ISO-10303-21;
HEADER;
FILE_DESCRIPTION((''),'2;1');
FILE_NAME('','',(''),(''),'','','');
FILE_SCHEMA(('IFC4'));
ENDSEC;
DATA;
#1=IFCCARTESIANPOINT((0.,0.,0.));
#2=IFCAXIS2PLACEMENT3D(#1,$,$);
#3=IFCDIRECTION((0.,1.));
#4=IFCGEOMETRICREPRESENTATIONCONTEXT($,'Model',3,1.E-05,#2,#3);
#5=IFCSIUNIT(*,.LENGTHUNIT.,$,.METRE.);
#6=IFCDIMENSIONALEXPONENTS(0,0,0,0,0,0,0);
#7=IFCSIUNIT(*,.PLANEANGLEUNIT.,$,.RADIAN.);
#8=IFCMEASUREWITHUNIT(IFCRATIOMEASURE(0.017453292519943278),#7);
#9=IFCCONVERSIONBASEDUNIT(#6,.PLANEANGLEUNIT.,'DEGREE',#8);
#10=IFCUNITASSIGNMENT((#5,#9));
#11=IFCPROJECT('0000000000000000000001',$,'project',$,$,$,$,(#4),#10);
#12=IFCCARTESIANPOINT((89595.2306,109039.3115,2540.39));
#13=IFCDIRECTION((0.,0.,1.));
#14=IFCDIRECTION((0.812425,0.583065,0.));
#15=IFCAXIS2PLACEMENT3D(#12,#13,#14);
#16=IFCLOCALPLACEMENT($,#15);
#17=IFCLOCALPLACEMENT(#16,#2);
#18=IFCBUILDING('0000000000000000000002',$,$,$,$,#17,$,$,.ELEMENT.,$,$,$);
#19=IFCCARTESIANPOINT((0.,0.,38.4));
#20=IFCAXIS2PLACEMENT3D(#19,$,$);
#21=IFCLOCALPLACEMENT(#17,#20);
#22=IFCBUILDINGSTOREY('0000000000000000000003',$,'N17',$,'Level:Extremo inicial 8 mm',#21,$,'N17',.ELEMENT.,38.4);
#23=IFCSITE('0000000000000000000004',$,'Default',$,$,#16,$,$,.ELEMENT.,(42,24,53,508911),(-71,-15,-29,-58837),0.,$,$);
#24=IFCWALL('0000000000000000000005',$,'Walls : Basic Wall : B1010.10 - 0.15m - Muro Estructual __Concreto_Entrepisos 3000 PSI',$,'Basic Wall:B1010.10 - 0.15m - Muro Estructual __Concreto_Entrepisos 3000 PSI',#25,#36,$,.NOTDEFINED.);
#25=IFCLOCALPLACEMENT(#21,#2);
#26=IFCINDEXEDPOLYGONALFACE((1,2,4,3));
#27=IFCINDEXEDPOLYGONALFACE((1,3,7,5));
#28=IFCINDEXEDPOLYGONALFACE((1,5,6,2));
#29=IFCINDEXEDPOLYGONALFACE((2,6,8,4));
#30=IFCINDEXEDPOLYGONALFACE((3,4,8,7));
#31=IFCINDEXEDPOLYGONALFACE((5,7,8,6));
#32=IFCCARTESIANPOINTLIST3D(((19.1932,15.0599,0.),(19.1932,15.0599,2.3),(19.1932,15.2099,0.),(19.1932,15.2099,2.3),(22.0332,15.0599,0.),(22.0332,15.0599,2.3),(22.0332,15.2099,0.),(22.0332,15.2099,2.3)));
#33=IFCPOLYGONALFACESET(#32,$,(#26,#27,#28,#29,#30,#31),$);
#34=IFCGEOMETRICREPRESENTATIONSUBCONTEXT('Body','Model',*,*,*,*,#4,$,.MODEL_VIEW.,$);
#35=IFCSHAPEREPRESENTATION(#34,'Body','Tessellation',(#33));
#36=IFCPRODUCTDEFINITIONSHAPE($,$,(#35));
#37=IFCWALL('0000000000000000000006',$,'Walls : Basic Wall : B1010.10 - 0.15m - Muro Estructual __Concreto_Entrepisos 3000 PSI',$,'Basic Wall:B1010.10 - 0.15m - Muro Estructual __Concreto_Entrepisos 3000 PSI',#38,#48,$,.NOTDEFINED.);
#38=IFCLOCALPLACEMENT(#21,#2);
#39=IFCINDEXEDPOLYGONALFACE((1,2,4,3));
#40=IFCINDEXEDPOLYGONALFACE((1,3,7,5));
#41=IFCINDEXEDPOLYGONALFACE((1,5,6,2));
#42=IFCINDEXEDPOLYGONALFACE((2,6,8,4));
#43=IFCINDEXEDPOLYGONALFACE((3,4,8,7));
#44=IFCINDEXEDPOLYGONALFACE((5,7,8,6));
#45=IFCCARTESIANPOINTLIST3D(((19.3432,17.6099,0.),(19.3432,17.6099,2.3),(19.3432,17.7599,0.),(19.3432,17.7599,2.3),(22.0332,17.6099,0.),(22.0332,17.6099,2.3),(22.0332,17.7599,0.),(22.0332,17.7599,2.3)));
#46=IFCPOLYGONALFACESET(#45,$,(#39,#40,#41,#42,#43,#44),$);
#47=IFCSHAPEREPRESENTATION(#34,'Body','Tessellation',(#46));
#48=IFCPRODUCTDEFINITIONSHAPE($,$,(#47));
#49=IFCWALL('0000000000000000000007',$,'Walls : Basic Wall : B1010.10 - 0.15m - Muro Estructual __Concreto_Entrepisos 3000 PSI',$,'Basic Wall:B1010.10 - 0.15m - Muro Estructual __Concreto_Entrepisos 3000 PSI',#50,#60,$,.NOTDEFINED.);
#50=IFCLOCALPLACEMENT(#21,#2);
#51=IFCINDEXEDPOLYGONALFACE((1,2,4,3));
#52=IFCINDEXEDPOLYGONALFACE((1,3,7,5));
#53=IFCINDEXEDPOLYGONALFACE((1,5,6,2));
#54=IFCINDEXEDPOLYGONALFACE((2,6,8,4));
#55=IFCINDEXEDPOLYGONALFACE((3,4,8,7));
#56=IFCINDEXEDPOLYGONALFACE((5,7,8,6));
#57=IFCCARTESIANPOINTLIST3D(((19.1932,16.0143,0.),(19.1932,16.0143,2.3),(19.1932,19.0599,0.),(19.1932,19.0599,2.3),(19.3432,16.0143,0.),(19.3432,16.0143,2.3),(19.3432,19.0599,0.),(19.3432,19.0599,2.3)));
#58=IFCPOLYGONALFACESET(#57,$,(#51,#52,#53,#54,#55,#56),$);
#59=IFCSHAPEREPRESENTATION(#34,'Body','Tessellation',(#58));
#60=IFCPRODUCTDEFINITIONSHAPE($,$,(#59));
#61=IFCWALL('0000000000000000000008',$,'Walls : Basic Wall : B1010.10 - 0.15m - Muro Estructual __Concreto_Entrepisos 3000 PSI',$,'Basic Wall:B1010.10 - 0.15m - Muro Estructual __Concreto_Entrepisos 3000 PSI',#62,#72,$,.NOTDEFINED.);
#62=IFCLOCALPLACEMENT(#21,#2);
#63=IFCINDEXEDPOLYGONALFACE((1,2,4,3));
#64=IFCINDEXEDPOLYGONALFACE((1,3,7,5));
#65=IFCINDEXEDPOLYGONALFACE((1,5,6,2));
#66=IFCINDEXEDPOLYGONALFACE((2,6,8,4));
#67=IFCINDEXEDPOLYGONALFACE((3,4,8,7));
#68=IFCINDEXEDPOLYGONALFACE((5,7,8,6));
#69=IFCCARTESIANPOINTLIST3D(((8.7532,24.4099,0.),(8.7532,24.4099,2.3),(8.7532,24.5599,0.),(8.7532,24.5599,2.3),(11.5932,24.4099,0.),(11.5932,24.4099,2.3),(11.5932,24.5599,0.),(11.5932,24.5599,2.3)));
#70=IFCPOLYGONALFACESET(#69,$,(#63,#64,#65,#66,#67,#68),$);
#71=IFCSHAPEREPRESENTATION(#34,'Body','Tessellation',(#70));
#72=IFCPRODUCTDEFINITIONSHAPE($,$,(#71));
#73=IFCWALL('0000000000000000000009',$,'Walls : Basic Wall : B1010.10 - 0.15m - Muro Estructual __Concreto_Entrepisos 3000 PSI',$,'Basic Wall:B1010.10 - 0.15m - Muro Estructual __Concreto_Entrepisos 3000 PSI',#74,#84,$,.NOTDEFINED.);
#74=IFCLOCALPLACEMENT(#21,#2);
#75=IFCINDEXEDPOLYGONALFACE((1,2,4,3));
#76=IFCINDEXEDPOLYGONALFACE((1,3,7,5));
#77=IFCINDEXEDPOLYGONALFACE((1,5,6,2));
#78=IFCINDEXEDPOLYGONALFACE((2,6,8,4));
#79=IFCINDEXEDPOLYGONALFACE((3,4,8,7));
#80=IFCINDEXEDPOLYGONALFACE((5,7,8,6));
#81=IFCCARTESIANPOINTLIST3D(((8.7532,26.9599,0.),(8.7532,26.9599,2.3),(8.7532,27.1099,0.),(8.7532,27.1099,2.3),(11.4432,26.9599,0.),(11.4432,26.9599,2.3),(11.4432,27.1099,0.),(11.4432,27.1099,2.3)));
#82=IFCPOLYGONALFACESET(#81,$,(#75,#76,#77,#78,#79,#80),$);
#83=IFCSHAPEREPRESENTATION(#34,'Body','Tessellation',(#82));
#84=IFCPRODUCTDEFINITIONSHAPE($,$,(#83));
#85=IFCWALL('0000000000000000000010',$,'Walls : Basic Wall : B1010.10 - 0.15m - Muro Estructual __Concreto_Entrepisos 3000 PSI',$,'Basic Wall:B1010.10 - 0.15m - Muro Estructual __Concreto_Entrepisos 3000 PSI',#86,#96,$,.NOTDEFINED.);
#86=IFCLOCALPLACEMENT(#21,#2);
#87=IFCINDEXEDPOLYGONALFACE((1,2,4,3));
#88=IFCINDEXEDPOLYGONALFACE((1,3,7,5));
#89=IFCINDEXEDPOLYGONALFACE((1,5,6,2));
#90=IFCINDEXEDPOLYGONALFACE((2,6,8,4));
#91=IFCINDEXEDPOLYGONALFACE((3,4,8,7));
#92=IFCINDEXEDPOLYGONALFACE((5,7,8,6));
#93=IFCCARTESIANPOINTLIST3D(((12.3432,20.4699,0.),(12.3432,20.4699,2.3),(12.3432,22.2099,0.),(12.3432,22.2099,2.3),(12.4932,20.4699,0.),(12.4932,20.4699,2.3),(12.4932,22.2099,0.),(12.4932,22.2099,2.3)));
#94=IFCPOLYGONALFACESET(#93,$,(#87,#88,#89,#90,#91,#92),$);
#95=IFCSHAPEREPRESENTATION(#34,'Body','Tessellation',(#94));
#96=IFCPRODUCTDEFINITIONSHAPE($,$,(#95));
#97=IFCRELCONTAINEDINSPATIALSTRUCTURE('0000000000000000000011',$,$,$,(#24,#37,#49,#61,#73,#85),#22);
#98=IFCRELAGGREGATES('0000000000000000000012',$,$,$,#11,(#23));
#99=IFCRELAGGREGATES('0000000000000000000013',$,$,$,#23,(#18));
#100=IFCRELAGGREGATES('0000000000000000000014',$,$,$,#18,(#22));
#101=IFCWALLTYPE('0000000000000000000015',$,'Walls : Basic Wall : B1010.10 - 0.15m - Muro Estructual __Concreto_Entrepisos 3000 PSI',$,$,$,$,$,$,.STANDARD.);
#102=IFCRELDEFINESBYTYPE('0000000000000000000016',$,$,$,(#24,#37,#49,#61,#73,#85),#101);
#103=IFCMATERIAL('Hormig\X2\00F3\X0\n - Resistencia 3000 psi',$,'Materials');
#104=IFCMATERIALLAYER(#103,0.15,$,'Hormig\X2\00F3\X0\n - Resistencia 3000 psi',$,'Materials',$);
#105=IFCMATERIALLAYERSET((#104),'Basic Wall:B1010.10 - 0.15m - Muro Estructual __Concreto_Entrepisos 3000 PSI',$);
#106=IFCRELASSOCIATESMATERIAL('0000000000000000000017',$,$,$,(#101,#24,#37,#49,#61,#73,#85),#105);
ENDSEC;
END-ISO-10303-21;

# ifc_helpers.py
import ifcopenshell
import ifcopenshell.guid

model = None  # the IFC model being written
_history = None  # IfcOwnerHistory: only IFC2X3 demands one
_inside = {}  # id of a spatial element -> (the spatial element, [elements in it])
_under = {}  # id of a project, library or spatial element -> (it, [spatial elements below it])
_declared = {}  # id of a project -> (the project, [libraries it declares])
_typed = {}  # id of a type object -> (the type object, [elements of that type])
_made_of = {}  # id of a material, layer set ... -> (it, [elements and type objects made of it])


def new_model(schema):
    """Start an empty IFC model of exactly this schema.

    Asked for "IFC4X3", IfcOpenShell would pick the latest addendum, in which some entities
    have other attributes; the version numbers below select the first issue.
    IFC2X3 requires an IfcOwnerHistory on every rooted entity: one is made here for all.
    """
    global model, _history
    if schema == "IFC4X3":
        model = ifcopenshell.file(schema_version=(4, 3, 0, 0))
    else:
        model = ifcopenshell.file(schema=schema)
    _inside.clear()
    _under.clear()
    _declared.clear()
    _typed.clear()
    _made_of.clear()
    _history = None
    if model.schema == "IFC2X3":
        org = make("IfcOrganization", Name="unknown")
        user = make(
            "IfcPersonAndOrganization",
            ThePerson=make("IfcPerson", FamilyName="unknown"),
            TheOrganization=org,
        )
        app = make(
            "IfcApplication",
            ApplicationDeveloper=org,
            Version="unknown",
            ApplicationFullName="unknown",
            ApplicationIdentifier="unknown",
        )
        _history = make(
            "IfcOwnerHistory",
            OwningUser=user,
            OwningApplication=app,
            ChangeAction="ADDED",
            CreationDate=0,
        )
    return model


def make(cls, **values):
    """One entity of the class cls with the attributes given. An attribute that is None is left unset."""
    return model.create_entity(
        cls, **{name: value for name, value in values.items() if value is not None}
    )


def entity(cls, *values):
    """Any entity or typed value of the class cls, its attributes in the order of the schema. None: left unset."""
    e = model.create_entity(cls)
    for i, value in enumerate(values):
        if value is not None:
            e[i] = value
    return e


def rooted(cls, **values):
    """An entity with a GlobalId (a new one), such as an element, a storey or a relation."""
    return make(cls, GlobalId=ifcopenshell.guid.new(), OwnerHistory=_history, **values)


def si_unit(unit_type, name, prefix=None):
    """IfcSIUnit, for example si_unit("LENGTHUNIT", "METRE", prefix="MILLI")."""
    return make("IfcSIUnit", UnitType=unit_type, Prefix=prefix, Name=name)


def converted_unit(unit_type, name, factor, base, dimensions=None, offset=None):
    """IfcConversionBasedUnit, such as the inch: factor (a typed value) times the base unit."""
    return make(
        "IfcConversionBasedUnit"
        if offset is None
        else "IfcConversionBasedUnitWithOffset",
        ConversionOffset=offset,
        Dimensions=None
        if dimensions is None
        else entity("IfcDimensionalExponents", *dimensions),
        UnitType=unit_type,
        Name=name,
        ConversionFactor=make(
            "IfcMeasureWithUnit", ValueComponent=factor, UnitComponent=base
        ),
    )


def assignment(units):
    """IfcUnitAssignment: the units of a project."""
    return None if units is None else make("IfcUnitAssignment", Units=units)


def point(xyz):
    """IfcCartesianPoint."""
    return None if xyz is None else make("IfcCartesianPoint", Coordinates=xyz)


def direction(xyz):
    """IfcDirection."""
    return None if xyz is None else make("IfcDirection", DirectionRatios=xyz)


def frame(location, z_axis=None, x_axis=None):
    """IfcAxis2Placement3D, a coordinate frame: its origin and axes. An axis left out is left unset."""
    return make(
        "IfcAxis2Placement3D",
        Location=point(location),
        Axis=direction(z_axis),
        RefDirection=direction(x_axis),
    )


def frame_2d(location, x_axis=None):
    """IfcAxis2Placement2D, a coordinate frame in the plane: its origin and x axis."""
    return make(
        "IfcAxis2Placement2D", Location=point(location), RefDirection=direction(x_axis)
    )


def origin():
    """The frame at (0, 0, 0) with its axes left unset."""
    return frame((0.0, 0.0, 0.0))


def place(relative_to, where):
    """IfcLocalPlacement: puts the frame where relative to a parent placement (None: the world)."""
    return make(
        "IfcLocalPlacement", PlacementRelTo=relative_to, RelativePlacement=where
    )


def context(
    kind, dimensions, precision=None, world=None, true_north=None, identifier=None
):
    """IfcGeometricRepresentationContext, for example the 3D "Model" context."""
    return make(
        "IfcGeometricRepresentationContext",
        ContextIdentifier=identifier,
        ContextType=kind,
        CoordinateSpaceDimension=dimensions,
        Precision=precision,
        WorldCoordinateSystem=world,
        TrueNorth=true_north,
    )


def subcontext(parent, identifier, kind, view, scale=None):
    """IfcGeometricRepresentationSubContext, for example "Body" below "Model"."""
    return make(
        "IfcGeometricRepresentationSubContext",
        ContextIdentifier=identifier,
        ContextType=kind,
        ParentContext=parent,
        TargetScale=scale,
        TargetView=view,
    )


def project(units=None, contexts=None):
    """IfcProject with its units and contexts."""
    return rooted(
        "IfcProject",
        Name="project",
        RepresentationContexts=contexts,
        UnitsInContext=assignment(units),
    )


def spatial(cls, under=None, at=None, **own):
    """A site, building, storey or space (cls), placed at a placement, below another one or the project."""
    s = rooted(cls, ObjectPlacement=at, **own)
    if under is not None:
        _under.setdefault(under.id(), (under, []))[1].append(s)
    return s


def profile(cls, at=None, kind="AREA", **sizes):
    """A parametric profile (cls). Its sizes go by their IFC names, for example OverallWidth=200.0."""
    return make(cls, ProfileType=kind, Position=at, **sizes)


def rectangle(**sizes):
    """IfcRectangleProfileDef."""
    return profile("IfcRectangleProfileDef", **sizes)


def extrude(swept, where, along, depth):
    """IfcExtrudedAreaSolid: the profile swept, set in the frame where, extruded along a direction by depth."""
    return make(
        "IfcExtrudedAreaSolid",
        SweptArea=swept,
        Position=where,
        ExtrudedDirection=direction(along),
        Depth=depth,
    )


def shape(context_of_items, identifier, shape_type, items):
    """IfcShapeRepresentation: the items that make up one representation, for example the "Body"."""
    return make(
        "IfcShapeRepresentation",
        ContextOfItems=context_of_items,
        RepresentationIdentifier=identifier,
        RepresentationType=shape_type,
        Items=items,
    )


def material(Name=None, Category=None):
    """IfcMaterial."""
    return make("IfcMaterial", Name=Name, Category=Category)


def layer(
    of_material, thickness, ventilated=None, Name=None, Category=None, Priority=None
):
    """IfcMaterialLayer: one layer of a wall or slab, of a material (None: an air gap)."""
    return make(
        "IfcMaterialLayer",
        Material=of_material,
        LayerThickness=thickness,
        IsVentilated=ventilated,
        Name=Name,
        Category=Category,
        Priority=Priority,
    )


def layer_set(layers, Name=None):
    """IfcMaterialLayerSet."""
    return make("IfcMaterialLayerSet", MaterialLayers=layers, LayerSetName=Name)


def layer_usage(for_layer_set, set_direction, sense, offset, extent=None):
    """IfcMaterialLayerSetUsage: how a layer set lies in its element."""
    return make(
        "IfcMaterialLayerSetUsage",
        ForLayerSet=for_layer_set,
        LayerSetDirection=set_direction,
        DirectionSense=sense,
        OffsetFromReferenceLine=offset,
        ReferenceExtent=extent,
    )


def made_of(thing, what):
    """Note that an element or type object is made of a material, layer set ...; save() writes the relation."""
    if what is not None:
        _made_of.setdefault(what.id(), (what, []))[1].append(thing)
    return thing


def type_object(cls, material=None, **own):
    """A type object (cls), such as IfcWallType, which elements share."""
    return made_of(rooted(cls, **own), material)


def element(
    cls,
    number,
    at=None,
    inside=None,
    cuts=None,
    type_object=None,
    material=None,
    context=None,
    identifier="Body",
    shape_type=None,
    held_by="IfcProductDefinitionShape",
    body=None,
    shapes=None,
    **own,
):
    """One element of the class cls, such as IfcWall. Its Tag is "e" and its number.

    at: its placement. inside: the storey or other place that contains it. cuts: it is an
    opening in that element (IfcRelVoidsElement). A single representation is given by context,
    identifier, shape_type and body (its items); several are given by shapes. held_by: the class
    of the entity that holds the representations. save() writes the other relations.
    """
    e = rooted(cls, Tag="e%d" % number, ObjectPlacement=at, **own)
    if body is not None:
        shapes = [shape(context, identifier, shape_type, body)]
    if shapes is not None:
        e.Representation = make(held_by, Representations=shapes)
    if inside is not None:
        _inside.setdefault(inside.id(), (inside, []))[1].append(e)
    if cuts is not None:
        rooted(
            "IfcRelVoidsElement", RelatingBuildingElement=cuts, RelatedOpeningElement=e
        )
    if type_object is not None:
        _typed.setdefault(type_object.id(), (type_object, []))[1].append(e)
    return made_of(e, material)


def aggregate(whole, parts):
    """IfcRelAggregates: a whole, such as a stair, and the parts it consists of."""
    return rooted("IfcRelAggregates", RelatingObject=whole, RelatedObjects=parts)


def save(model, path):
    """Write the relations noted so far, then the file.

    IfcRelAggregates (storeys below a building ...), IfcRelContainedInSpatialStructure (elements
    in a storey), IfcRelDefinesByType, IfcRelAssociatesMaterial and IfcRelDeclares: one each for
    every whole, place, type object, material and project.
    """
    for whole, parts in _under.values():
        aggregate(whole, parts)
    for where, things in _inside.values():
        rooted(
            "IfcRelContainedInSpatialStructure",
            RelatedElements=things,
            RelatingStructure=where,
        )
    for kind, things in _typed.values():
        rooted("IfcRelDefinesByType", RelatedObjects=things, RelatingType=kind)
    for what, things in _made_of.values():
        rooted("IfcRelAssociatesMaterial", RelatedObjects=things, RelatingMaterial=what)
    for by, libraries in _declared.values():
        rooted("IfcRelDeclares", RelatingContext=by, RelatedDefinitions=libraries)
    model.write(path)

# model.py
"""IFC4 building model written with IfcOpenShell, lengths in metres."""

from ifc_helpers import new_model, entity, si_unit, converted_unit, direction, frame, frame_2d, origin, place, context, subcontext, project, spatial, rectangle, extrude, material, layer, layer_set, layer_usage, type_object, element, save


model = new_model("IFC4")

# Units and contexts
model_context = context("Model", 3, precision=1e-05, world=origin(), true_north=direction((0.0, 1.0)))
body_context = subcontext(model_context, "Body", "Model", "MODEL_VIEW")
ifc_project = project(units=[si_unit("LENGTHUNIT", "METRE"), converted_unit("PLANEANGLEUNIT", "DEGREE", entity("IfcRatioMeasure", 0.017453292519943278), si_unit("PLANEANGLEUNIT", "RADIAN"), dimensions=[0, 0, 0, 0, 0, 0, 0])], contexts=[model_context])

# Site, building, storey
site_placement = place(None, frame((89595.2306, 109039.3115, 2540.39), z_axis=(0.0, 0.0, 1.0), x_axis=(0.812425, 0.583065, 0.0)))
site = spatial("IfcSite", under=ifc_project, at=site_placement, Name="Default", CompositionType="ELEMENT", RefLatitude=(42, 24, 53, 508911), RefLongitude=(-71, -15, -29, -58837), RefElevation=0.0)
building_placement = place(site_placement, origin())
building = spatial("IfcBuilding", under=site, at=building_placement, CompositionType="ELEMENT")
storey_placement = place(building_placement, frame((0.0, 0.0, 38.4)))
storey = spatial("IfcBuildingStorey", under=building, at=storey_placement, Name="N17", ObjectType="Level:Extremo inicial 8 mm", LongName="N17", CompositionType="ELEMENT", Elevation=38.4)

# Walls
ifc_material = material(Name="Hormigón - Resistencia 3000 psi", Category="Materials")
ifc_layer_1 = layer(ifc_material, 0.15, Name="Hormigón - Resistencia 3000 psi", Category="Materials")
ifc_layer_set_1 = layer_set([ifc_layer_1], Name="Basic Wall:B1010.10 - 0.15m - Muro Estructual __Concreto_Entrepisos 3000 PSI")
ifc_layer_usage_1 = layer_usage(ifc_layer_set_1, "AXIS2", "NEGATIVE", 0.075)
wall_type_1 = type_object("IfcWallType", Name="Walls : Basic Wall : B1010.10 - 0.15m - Muro Estructual __Concreto_Entrepisos 3000 PSI", PredefinedType="STANDARD", material=ifc_layer_set_1)
wall_1_placement = place(storey_placement, frame((22.0332, 15.1349, 0.0), z_axis=(0.0, 0.0, 1.0), x_axis=(-1.0, 0.0, 0.0)))
element("IfcWall", 1, at=wall_1_placement, inside=storey, type_object=wall_type_1, material=ifc_layer_usage_1, Name="Walls : Basic Wall : B1010.10 - 0.15m - Muro Estructual __Concreto_Entrepisos 3000 PSI", ObjectType="Basic Wall:B1010.10 - 0.15m - Muro Estructual __Concreto_Entrepisos 3000 PSI", PredefinedType="NOTDEFINED", context=body_context, shape_type="SweptSolid", body=[
    extrude(rectangle(XDim=2.84, YDim=0.15, at=frame_2d((1.42, 0.0), x_axis=(-1.0, 0.0))), origin(), (0.0, 0.0, 1.0), 2.3),
])
ifc_layer_usage_2 = layer_usage(ifc_layer_set_1, "AXIS2", "NEGATIVE", 0.075)
wall_2_placement = place(storey_placement, frame((22.0332, 17.6849, 0.0), z_axis=(0.0, 0.0, 1.0), x_axis=(-1.0, 0.0, 0.0)))
element("IfcWall", 2, at=wall_2_placement, inside=storey, type_object=wall_type_1, material=ifc_layer_usage_2, Name="Walls : Basic Wall : B1010.10 - 0.15m - Muro Estructual __Concreto_Entrepisos 3000 PSI", ObjectType="Basic Wall:B1010.10 - 0.15m - Muro Estructual __Concreto_Entrepisos 3000 PSI", PredefinedType="NOTDEFINED", context=body_context, shape_type="SweptSolid", body=[
    extrude(rectangle(XDim=2.69, YDim=0.15, at=frame_2d((1.345, 0.0), x_axis=(-1.0, 0.0))), origin(), (0.0, 0.0, 1.0), 2.3),
])
ifc_layer_usage_3 = layer_usage(ifc_layer_set_1, "AXIS2", "NEGATIVE", 0.075)
wall_3_placement = place(storey_placement, frame((19.2682, 16.0143, 0.0), z_axis=(0.0, 0.0, 1.0), x_axis=(0.0, 1.0, 0.0)))
element("IfcWall", 3, at=wall_3_placement, inside=storey, type_object=wall_type_1, material=ifc_layer_usage_3, Name="Walls : Basic Wall : B1010.10 - 0.15m - Muro Estructual __Concreto_Entrepisos 3000 PSI", ObjectType="Basic Wall:B1010.10 - 0.15m - Muro Estructual __Concreto_Entrepisos 3000 PSI", PredefinedType="NOTDEFINED", context=body_context, shape_type="SweptSolid", body=[
    extrude(rectangle(XDim=3.0455, YDim=0.15, at=frame_2d((1.5228, 0.0), x_axis=(-1.0, 0.0))), origin(), (0.0, 0.0, 1.0), 2.3),
])
ifc_layer_usage_4 = layer_usage(ifc_layer_set_1, "AXIS2", "NEGATIVE", 0.075)
wall_4_placement = place(storey_placement, frame((8.7532, 24.4849, 0.0)))
element("IfcWall", 4, at=wall_4_placement, inside=storey, type_object=wall_type_1, material=ifc_layer_usage_4, Name="Walls : Basic Wall : B1010.10 - 0.15m - Muro Estructual __Concreto_Entrepisos 3000 PSI", ObjectType="Basic Wall:B1010.10 - 0.15m - Muro Estructual __Concreto_Entrepisos 3000 PSI", PredefinedType="NOTDEFINED", context=body_context, shape_type="SweptSolid", body=[
    extrude(rectangle(XDim=2.84, YDim=0.15, at=frame_2d((1.42, 0.0), x_axis=(-1.0, 0.0))), origin(), (0.0, 0.0, 1.0), 2.3),
])
ifc_layer_usage_5 = layer_usage(ifc_layer_set_1, "AXIS2", "NEGATIVE", 0.075)
wall_5_placement = place(storey_placement, frame((8.7532, 27.0349, 0.0)))
element("IfcWall", 5, at=wall_5_placement, inside=storey, type_object=wall_type_1, material=ifc_layer_usage_5, Name="Walls : Basic Wall : B1010.10 - 0.15m - Muro Estructual __Concreto_Entrepisos 3000 PSI", ObjectType="Basic Wall:B1010.10 - 0.15m - Muro Estructual __Concreto_Entrepisos 3000 PSI", PredefinedType="NOTDEFINED", context=body_context, shape_type="SweptSolid", body=[
    extrude(rectangle(XDim=2.69, YDim=0.15, at=frame_2d((1.345, 0.0), x_axis=(-1.0, 0.0))), origin(), (0.0, 0.0, 1.0), 2.3),
])
ifc_layer_usage_6 = layer_usage(ifc_layer_set_1, "AXIS2", "POSITIVE", -0.075)
wall_6_placement = place(storey_placement, frame((12.4182, 20.4699, 0.0), z_axis=(0.0, 0.0, 1.0), x_axis=(0.0, 1.0, 0.0)))
element("IfcWall", 6, at=wall_6_placement, inside=storey, type_object=wall_type_1, material=ifc_layer_usage_6, Name="Walls : Basic Wall : B1010.10 - 0.15m - Muro Estructual __Concreto_Entrepisos 3000 PSI", ObjectType="Basic Wall:B1010.10 - 0.15m - Muro Estructual __Concreto_Entrepisos 3000 PSI", PredefinedType="NOTDEFINED", context=body_context, shape_type="SweptSolid", body=[
    extrude(rectangle(XDim=1.74, YDim=0.15, at=frame_2d((0.87, 0.0), x_axis=(-1.0, 0.0))), origin(), (0.0, 0.0, 1.0), 2.3),
])

save(model, "model.ifc")
